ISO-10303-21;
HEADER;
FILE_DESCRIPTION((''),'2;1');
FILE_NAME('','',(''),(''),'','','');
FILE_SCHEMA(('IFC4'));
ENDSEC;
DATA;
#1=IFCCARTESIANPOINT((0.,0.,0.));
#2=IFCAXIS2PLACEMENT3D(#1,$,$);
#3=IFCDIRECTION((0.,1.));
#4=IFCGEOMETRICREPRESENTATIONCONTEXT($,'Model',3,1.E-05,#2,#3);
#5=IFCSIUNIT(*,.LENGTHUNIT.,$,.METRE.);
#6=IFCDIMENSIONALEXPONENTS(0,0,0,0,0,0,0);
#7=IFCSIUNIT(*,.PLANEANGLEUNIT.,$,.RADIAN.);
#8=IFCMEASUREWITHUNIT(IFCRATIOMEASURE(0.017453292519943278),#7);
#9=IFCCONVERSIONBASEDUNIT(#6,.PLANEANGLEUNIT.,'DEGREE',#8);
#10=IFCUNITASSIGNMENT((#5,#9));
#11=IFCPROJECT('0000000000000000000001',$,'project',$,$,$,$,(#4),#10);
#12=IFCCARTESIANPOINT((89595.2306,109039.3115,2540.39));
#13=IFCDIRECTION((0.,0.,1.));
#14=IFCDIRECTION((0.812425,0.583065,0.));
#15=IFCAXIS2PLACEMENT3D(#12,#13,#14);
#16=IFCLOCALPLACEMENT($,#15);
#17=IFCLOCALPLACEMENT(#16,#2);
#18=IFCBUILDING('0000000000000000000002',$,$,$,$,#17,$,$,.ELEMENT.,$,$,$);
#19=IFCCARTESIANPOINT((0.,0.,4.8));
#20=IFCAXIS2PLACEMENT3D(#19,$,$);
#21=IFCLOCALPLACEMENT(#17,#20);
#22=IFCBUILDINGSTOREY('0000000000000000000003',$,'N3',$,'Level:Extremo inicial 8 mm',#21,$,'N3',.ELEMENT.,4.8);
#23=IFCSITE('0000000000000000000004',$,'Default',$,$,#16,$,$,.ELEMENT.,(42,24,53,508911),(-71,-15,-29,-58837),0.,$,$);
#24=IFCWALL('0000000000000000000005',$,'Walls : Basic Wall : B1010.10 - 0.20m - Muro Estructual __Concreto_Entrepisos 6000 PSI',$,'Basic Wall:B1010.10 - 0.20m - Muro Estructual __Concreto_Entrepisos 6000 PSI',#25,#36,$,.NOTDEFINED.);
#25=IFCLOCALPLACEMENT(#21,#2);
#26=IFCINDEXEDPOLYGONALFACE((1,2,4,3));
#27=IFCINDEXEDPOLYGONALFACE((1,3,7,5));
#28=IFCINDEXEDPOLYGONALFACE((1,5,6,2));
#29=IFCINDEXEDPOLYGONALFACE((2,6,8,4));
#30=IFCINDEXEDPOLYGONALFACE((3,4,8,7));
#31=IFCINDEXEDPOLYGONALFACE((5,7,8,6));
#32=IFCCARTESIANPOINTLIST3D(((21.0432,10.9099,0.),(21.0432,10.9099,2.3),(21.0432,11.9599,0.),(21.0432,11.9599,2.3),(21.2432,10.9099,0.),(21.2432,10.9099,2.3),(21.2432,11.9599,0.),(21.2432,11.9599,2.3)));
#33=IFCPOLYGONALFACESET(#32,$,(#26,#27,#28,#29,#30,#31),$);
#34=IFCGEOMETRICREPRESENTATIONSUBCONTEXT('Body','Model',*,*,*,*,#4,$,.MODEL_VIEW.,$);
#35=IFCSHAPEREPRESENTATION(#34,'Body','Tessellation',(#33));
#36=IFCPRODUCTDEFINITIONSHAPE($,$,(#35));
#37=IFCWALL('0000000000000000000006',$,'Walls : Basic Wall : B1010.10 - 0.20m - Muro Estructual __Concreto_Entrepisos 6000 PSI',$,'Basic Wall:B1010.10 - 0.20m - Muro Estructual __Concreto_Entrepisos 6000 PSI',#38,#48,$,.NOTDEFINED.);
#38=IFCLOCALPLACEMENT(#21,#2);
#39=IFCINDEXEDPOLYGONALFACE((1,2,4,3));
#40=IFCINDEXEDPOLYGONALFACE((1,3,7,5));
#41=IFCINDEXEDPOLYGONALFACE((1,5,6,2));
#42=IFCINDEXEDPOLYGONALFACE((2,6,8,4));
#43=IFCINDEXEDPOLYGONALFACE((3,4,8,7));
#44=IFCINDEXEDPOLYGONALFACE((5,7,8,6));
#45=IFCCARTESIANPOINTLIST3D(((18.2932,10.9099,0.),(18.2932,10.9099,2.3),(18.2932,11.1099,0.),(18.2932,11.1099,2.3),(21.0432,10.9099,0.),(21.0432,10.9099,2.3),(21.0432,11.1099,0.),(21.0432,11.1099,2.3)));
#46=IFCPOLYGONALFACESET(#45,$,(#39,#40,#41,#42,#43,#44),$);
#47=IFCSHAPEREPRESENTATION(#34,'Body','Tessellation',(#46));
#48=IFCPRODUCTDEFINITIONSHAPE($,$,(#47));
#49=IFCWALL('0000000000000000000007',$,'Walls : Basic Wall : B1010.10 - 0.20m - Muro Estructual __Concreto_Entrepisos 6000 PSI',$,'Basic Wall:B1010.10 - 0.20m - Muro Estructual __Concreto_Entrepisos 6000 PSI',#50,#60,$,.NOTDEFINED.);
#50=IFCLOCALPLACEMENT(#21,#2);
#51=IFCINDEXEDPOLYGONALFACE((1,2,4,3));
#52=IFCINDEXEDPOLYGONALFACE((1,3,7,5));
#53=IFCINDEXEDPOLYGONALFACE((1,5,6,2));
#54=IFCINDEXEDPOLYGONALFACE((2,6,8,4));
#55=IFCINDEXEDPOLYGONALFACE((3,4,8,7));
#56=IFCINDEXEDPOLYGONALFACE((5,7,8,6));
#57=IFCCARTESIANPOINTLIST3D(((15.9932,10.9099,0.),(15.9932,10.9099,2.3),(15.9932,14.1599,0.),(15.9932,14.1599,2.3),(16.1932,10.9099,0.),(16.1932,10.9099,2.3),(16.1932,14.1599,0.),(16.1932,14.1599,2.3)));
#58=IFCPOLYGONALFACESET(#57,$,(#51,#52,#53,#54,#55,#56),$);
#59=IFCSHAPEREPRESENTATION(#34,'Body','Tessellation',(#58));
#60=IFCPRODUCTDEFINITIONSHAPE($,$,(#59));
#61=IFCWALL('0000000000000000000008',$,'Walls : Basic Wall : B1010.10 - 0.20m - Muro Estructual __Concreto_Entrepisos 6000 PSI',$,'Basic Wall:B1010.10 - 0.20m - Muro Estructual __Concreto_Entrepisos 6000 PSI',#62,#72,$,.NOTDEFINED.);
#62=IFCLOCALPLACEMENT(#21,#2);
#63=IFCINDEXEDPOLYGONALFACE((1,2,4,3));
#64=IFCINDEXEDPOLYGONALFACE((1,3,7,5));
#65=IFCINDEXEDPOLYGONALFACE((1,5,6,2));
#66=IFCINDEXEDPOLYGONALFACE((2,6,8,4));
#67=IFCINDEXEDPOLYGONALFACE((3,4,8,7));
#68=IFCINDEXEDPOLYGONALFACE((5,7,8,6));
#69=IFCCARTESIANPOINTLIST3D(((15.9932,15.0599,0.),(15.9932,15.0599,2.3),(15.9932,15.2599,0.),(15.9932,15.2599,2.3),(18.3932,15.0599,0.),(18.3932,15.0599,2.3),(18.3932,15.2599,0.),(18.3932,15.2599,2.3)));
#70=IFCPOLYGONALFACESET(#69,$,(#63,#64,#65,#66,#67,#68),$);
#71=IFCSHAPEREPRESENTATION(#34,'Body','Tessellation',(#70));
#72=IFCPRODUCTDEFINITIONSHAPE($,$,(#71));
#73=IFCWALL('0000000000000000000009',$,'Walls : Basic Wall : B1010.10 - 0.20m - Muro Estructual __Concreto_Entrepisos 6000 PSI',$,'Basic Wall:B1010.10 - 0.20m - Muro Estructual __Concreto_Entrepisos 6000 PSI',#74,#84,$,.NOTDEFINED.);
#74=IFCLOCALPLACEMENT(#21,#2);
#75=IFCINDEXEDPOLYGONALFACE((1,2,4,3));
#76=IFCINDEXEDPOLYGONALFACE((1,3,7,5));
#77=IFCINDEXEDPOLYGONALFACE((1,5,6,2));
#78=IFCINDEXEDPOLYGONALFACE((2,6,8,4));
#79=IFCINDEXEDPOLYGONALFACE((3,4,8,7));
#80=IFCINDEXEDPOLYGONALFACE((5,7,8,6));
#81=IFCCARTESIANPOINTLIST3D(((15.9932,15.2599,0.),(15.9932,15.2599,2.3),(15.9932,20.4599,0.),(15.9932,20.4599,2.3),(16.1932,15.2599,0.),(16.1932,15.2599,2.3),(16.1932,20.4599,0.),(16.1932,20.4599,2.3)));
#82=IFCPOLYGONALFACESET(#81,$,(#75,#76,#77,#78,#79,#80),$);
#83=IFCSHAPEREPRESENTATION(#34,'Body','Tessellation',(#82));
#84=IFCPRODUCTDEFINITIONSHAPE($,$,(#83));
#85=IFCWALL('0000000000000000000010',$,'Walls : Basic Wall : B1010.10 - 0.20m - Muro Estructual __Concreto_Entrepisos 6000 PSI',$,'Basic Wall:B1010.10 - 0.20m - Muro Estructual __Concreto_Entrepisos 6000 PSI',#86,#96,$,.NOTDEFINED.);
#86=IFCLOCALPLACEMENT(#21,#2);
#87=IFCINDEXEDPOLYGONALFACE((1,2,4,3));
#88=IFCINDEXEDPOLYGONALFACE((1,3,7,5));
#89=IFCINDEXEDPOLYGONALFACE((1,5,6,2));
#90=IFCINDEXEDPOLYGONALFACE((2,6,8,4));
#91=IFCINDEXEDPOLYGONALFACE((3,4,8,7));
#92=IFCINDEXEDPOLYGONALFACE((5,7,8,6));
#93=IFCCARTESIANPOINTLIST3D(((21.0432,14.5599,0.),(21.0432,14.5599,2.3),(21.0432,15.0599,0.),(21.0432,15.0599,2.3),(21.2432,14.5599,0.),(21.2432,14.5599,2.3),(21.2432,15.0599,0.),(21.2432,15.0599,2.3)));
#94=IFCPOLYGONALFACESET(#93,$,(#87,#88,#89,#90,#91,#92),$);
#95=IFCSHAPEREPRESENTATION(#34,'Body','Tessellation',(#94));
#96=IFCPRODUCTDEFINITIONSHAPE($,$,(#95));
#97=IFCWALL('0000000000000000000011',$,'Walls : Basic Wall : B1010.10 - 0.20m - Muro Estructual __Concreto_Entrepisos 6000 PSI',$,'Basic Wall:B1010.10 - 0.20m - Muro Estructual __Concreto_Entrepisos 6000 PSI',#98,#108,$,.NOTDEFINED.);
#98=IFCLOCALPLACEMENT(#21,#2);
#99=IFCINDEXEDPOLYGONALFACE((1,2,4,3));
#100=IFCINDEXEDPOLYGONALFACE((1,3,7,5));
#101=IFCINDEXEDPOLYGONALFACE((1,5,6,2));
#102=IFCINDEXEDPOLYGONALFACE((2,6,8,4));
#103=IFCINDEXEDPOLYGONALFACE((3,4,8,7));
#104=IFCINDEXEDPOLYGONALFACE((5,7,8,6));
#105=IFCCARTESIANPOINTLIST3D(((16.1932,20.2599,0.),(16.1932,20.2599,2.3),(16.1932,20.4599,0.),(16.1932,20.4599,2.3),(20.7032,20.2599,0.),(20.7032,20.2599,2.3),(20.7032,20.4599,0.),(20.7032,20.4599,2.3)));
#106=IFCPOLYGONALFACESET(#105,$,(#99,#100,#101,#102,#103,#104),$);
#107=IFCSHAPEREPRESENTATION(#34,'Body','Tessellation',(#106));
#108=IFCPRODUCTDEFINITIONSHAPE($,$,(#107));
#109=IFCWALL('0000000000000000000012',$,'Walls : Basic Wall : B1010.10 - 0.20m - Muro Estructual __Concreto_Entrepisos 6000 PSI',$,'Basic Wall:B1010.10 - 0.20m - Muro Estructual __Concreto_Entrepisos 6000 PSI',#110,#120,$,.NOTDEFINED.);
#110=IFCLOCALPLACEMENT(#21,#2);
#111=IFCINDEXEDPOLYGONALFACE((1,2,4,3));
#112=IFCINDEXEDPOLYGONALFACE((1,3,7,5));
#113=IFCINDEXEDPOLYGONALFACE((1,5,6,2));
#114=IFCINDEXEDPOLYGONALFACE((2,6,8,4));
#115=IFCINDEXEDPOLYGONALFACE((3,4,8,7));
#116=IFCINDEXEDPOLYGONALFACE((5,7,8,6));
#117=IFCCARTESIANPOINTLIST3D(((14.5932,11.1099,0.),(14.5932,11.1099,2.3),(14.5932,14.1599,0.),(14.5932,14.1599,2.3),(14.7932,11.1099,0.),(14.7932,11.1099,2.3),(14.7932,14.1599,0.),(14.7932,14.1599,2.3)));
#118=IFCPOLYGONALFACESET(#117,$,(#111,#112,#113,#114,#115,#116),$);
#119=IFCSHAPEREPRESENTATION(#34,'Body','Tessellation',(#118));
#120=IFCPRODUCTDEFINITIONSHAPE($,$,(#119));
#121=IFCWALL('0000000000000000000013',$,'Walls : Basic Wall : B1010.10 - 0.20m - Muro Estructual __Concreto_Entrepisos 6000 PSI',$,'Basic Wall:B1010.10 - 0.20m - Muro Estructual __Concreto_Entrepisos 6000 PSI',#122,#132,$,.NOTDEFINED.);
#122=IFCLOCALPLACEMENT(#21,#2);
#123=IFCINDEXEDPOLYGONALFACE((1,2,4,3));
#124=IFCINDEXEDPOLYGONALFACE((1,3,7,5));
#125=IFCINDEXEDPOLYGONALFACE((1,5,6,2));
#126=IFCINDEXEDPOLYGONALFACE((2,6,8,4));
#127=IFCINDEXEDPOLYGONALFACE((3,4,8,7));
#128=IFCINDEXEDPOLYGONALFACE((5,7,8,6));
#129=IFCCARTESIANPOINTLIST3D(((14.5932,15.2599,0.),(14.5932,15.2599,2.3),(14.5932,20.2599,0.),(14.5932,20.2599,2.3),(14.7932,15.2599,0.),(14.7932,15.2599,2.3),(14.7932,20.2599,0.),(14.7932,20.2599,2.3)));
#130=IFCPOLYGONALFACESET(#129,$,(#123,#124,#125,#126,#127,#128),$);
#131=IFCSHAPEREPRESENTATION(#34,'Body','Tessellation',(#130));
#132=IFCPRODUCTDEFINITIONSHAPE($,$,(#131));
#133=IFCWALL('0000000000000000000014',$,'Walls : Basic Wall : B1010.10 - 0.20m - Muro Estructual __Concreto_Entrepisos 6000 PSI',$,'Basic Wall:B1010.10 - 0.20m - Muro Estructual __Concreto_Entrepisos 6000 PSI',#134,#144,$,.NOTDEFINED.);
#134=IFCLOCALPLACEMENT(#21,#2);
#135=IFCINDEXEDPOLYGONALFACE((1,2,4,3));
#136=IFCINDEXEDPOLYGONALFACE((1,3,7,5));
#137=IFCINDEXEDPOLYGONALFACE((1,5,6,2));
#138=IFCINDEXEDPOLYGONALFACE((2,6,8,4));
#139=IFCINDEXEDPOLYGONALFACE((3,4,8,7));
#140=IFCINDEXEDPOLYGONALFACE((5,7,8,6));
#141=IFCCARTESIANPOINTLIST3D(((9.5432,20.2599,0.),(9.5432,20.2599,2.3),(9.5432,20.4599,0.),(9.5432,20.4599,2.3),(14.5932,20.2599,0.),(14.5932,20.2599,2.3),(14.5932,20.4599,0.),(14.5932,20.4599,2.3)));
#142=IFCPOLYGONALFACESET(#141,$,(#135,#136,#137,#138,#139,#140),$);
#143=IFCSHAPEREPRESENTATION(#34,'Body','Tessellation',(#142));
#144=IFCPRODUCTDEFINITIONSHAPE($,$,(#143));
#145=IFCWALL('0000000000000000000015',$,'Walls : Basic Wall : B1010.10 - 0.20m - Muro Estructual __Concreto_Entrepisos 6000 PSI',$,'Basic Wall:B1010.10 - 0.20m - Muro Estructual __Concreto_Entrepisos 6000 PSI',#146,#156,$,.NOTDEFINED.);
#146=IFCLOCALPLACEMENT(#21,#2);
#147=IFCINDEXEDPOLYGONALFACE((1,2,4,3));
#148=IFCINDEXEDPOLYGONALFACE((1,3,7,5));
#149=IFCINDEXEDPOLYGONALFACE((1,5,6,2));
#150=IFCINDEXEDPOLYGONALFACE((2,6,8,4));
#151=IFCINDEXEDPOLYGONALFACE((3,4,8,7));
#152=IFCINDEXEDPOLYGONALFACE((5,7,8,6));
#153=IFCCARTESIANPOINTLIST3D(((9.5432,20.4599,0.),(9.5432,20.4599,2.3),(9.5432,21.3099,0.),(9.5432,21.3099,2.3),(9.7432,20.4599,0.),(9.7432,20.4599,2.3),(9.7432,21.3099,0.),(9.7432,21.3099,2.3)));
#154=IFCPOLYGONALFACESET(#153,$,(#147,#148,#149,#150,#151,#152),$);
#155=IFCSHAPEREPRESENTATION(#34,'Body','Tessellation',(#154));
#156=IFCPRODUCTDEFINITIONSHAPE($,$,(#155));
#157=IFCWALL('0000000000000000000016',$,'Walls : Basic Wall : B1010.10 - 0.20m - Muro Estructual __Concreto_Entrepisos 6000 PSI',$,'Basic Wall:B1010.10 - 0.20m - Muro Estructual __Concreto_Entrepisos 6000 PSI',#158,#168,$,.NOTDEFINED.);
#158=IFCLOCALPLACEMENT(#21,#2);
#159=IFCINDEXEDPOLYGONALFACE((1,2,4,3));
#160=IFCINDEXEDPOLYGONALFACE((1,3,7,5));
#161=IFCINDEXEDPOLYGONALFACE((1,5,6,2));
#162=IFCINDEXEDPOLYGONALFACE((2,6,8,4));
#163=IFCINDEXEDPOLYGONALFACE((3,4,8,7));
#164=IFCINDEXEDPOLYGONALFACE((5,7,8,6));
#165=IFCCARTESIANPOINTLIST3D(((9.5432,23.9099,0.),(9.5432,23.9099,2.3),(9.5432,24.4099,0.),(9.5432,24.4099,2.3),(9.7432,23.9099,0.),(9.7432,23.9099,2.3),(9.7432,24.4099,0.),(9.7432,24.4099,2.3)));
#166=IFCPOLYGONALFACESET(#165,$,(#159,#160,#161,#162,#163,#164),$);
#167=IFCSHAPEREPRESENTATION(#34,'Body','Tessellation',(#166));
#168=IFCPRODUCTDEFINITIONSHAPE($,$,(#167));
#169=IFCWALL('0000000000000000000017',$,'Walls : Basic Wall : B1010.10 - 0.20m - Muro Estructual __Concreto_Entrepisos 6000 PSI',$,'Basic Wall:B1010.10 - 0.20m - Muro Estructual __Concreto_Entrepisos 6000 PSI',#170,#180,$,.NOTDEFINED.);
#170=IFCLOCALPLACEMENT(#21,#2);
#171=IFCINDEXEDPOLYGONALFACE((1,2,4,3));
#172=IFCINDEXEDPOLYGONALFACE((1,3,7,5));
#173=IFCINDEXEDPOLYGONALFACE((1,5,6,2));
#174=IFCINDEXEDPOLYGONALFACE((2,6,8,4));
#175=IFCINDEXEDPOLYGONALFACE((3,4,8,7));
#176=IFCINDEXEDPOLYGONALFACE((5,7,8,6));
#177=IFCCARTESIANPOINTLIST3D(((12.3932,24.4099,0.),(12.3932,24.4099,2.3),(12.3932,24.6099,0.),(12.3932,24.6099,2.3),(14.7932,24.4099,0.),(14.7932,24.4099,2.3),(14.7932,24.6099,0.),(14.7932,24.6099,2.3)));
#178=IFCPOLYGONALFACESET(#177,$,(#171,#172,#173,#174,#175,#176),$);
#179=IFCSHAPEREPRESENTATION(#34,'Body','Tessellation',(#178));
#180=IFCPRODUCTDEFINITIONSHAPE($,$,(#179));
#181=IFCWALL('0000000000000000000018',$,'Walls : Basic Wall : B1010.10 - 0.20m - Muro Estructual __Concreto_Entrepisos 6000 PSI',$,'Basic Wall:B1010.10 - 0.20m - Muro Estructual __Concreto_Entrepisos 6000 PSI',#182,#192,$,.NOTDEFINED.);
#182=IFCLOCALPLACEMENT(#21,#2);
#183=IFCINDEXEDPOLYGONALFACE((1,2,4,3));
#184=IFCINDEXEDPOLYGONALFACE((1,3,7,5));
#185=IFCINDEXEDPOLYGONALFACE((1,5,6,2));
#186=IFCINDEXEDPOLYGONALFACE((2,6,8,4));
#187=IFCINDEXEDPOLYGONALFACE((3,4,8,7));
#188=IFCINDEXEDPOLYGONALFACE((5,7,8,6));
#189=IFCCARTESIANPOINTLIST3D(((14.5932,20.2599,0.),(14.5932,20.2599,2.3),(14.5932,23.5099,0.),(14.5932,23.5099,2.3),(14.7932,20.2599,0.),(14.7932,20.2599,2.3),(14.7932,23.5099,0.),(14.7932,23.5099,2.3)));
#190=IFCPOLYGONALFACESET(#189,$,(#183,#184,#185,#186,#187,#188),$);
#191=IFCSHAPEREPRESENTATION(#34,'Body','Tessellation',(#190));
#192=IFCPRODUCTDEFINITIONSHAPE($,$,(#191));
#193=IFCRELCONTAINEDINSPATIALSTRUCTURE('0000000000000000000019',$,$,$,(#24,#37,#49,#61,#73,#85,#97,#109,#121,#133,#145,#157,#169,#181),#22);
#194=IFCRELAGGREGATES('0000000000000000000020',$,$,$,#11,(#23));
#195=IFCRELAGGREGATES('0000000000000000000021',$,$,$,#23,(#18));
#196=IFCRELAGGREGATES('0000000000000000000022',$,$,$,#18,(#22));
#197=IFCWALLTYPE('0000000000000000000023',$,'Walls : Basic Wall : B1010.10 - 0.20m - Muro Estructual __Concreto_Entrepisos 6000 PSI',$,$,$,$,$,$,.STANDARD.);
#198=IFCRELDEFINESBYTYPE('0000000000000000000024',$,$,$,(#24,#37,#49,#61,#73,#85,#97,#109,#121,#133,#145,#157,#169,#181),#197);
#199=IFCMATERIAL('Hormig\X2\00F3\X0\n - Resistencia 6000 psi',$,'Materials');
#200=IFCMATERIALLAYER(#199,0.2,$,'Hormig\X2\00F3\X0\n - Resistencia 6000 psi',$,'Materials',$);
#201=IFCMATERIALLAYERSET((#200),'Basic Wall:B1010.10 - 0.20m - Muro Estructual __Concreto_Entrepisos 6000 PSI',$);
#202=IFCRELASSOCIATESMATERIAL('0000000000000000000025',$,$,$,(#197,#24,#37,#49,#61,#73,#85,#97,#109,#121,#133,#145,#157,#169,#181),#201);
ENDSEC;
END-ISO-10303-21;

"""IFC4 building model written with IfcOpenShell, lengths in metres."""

from ifc_helpers import new_model, entity, si_unit, converted_unit, direction, frame, frame_2d, origin, place, context, subcontext, project, spatial, rectangle, extrude, material, layer, layer_set, layer_usage, type_object, element, save


model = new_model("IFC4")

# Units and contexts
model_context = context("Model", 3, precision=1e-05, world=origin(), true_north=direction((0.0, 1.0)))
body_context = subcontext(model_context, "Body", "Model", "MODEL_VIEW")
ifc_project = project(units=[si_unit("LENGTHUNIT", "METRE"), converted_unit("PLANEANGLEUNIT", "DEGREE", entity("IfcRatioMeasure", 0.017453292519943278), si_unit("PLANEANGLEUNIT", "RADIAN"), dimensions=[0, 0, 0, 0, 0, 0, 0])], contexts=[model_context])

# Site, building, storey
site_placement = place(None, frame((89595.2306, 109039.3115, 2540.39), z_axis=(0.0, 0.0, 1.0), x_axis=(0.812425, 0.583065, 0.0)))
site = spatial("IfcSite", under=ifc_project, at=site_placement, Name="Default", CompositionType="ELEMENT", RefLatitude=(42, 24, 53, 508911), RefLongitude=(-71, -15, -29, -58837), RefElevation=0.0)
building_placement = place(site_placement, origin())
building = spatial("IfcBuilding", under=site, at=building_placement, CompositionType="ELEMENT")
storey_placement = place(building_placement, frame((0.0, 0.0, 4.8)))
storey = spatial("IfcBuildingStorey", under=building, at=storey_placement, Name="N3", ObjectType="Level:Extremo inicial 8 mm", LongName="N3", CompositionType="ELEMENT", Elevation=4.8)

# Walls
ifc_material = material(Name="Hormigón - Resistencia 6000 psi", Category="Materials")
ifc_layer_1 = layer(ifc_material, 0.2, Name="Hormigón - Resistencia 6000 psi", Category="Materials")
ifc_layer_set_1 = layer_set([ifc_layer_1], Name="Basic Wall:B1010.10 - 0.20m - Muro Estructual __Concreto_Entrepisos 6000 PSI")
ifc_layer_usage_1 = layer_usage(ifc_layer_set_1, "AXIS2", "NEGATIVE", 0.1)
wall_type_1 = type_object("IfcWallType", Name="Walls : Basic Wall : B1010.10 - 0.20m - Muro Estructual __Concreto_Entrepisos 6000 PSI", PredefinedType="STANDARD", material=ifc_layer_set_1)
wall_1_placement = place(storey_placement, frame((21.1432, 11.9599, 0.0), z_axis=(0.0, 0.0, 1.0), x_axis=(0.0, -1.0, 0.0)))
element("IfcWall", 1, at=wall_1_placement, inside=storey, type_object=wall_type_1, material=ifc_layer_usage_1, Name="Walls : Basic Wall : B1010.10 - 0.20m - Muro Estructual __Concreto_Entrepisos 6000 PSI", ObjectType="Basic Wall:B1010.10 - 0.20m - Muro Estructual __Concreto_Entrepisos 6000 PSI", PredefinedType="NOTDEFINED", context=body_context, shape_type="SweptSolid", body=[
    extrude(rectangle(XDim=1.05, YDim=0.2, at=frame_2d((0.525, 0.0), x_axis=(-1.0, 0.0))), origin(), (0.0, 0.0, 1.0), 2.3),
])
ifc_layer_usage_2 = layer_usage(ifc_layer_set_1, "AXIS2", "NEGATIVE", 0.1)
wall_2_placement = place(storey_placement, frame((21.0432, 11.0099, 0.0), z_axis=(0.0, 0.0, 1.0), x_axis=(-1.0, 0.0, 0.0)))
element("IfcWall", 2, at=wall_2_placement, inside=storey, type_object=wall_type_1, material=ifc_layer_usage_2, Name="Walls : Basic Wall : B1010.10 - 0.20m - Muro Estructual __Concreto_Entrepisos 6000 PSI", ObjectType="Basic Wall:B1010.10 - 0.20m - Muro Estructual __Concreto_Entrepisos 6000 PSI", PredefinedType="NOTDEFINED", context=body_context, shape_type="SweptSolid", body=[
    extrude(rectangle(XDim=2.75, YDim=0.2, at=frame_2d((1.375, 0.0), x_axis=(-1.0, 0.0))), origin(), (0.0, 0.0, 1.0), 2.3),
])
ifc_layer_usage_3 = layer_usage(ifc_layer_set_1, "AXIS2", "NEGATIVE", 0.1)
wall_3_placement = place(storey_placement, frame((16.0932, 14.1599, 0.0), z_axis=(0.0, 0.0, 1.0), x_axis=(0.0, -1.0, 0.0)))
element("IfcWall", 3, at=wall_3_placement, inside=storey, type_object=wall_type_1, material=ifc_layer_usage_3, Name="Walls : Basic Wall : B1010.10 - 0.20m - Muro Estructual __Concreto_Entrepisos 6000 PSI", ObjectType="Basic Wall:B1010.10 - 0.20m - Muro Estructual __Concreto_Entrepisos 6000 PSI", PredefinedType="NOTDEFINED", context=body_context, shape_type="SweptSolid", body=[
    extrude(rectangle(XDim=3.25, YDim=0.2, at=frame_2d((1.625, 0.0), x_axis=(-1.0, 0.0))), origin(), (0.0, 0.0, 1.0), 2.3),
])
ifc_layer_usage_4 = layer_usage(ifc_layer_set_1, "AXIS2", "NEGATIVE", 0.1)
wall_4_placement = place(storey_placement, frame((18.3932, 15.1599, 0.0), z_axis=(0.0, 0.0, 1.0), x_axis=(-1.0, 0.0, 0.0)))
element("IfcWall", 4, at=wall_4_placement, inside=storey, type_object=wall_type_1, material=ifc_layer_usage_4, Name="Walls : Basic Wall : B1010.10 - 0.20m - Muro Estructual __Concreto_Entrepisos 6000 PSI", ObjectType="Basic Wall:B1010.10 - 0.20m - Muro Estructual __Concreto_Entrepisos 6000 PSI", PredefinedType="NOTDEFINED", context=body_context, shape_type="SweptSolid", body=[
    extrude(rectangle(XDim=2.4, YDim=0.2, at=frame_2d((1.2, 0.0), x_axis=(-1.0, 0.0))), origin(), (0.0, 0.0, 1.0), 2.3),
])
ifc_layer_usage_5 = layer_usage(ifc_layer_set_1, "AXIS2", "NEGATIVE", 0.1)
wall_5_placement = place(storey_placement, frame((16.0932, 15.2599, 0.0), z_axis=(0.0, 0.0, 1.0), x_axis=(0.0, 1.0, 0.0)))
element("IfcWall", 5, at=wall_5_placement, inside=storey, type_object=wall_type_1, material=ifc_layer_usage_5, Name="Walls : Basic Wall : B1010.10 - 0.20m - Muro Estructual __Concreto_Entrepisos 6000 PSI", ObjectType="Basic Wall:B1010.10 - 0.20m - Muro Estructual __Concreto_Entrepisos 6000 PSI", PredefinedType="NOTDEFINED", context=body_context, shape_type="SweptSolid", body=[
    extrude(rectangle(XDim=5.2, YDim=0.2, at=frame_2d((2.6, 0.0), x_axis=(-1.0, 0.0))), origin(), (0.0, 0.0, 1.0), 2.3),
])
ifc_layer_usage_6 = layer_usage(ifc_layer_set_1, "AXIS2", "NEGATIVE", 0.1)
wall_6_placement = place(storey_placement, frame((21.1432, 14.5599, 0.0), z_axis=(0.0, 0.0, 1.0), x_axis=(0.0, 1.0, 0.0)))
element("IfcWall", 6, at=wall_6_placement, inside=storey, type_object=wall_type_1, material=ifc_layer_usage_6, Name="Walls : Basic Wall : B1010.10 - 0.20m - Muro Estructual __Concreto_Entrepisos 6000 PSI", ObjectType="Basic Wall:B1010.10 - 0.20m - Muro Estructual __Concreto_Entrepisos 6000 PSI", PredefinedType="NOTDEFINED", context=body_context, shape_type="SweptSolid", body=[
    extrude(rectangle(XDim=0.5, YDim=0.2, at=frame_2d((0.25, 0.0), x_axis=(-1.0, 0.0))), origin(), (0.0, 0.0, 1.0), 2.3),
])
ifc_layer_usage_7 = layer_usage(ifc_layer_set_1, "AXIS2", "NEGATIVE", 0.1)
wall_7_placement = place(storey_placement, frame((16.1932, 20.3599, 0.0)))
element("IfcWall", 7, at=wall_7_placement, inside=storey, type_object=wall_type_1, material=ifc_layer_usage_7, Name="Walls : Basic Wall : B1010.10 - 0.20m - Muro Estructual __Concreto_Entrepisos 6000 PSI", ObjectType="Basic Wall:B1010.10 - 0.20m - Muro Estructual __Concreto_Entrepisos 6000 PSI", PredefinedType="NOTDEFINED", context=body_context, shape_type="SweptSolid", body=[
    extrude(rectangle(XDim=4.51, YDim=0.2, at=frame_2d((2.255, 0.0), x_axis=(-1.0, 0.0))), origin(), (0.0, 0.0, 1.0), 2.3),
])
ifc_layer_usage_8 = layer_usage(ifc_layer_set_1, "AXIS2", "POSITIVE", -0.1)
wall_8_placement = place(storey_placement, frame((14.6932, 14.1599, 0.0), z_axis=(0.0, 0.0, 1.0), x_axis=(0.0, -1.0, 0.0)))
element("IfcWall", 8, at=wall_8_placement, inside=storey, type_object=wall_type_1, material=ifc_layer_usage_8, Name="Walls : Basic Wall : B1010.10 - 0.20m - Muro Estructual __Concreto_Entrepisos 6000 PSI", ObjectType="Basic Wall:B1010.10 - 0.20m - Muro Estructual __Concreto_Entrepisos 6000 PSI", PredefinedType="NOTDEFINED", context=body_context, shape_type="SweptSolid", body=[
    extrude(rectangle(XDim=3.05, YDim=0.2, at=frame_2d((1.525, 0.0), x_axis=(-1.0, 0.0))), origin(), (0.0, 0.0, 1.0), 2.3),
])
ifc_layer_usage_9 = layer_usage(ifc_layer_set_1, "AXIS2", "POSITIVE", -0.1)
wall_9_placement = place(storey_placement, frame((14.6932, 15.2599, 0.0), z_axis=(0.0, 0.0, 1.0), x_axis=(0.0, 1.0, 0.0)))
element("IfcWall", 9, at=wall_9_placement, inside=storey, type_object=wall_type_1, material=ifc_layer_usage_9, Name="Walls : Basic Wall : B1010.10 - 0.20m - Muro Estructual __Concreto_Entrepisos 6000 PSI", ObjectType="Basic Wall:B1010.10 - 0.20m - Muro Estructual __Concreto_Entrepisos 6000 PSI", PredefinedType="NOTDEFINED", context=body_context, shape_type="SweptSolid", body=[
    extrude(rectangle(XDim=5.0, YDim=0.2, at=frame_2d((2.5, 0.0), x_axis=(-1.0, 0.0))), origin(), (0.0, 0.0, 1.0), 2.3),
])
ifc_layer_usage_10 = layer_usage(ifc_layer_set_1, "AXIS2", "POSITIVE", -0.1)
wall_10_placement = place(storey_placement, frame((14.5932, 20.3599, 0.0), z_axis=(0.0, 0.0, 1.0), x_axis=(-1.0, 0.0, 0.0)))
element("IfcWall", 10, at=wall_10_placement, inside=storey, type_object=wall_type_1, material=ifc_layer_usage_10, Name="Walls : Basic Wall : B1010.10 - 0.20m - Muro Estructual __Concreto_Entrepisos 6000 PSI", ObjectType="Basic Wall:B1010.10 - 0.20m - Muro Estructual __Concreto_Entrepisos 6000 PSI", PredefinedType="NOTDEFINED", context=body_context, shape_type="SweptSolid", body=[
    extrude(rectangle(XDim=5.05, YDim=0.2, at=frame_2d((2.525, 0.0), x_axis=(-1.0, 0.0))), origin(), (0.0, 0.0, 1.0), 2.3),
])
ifc_layer_usage_11 = layer_usage(ifc_layer_set_1, "AXIS2", "NEGATIVE", 0.1)
wall_11_placement = place(storey_placement, frame((9.6432, 20.4599, 0.0), z_axis=(0.0, 0.0, 1.0), x_axis=(0.0, 1.0, 0.0)))
element("IfcWall", 11, at=wall_11_placement, inside=storey, type_object=wall_type_1, material=ifc_layer_usage_11, Name="Walls : Basic Wall : B1010.10 - 0.20m - Muro Estructual __Concreto_Entrepisos 6000 PSI", ObjectType="Basic Wall:B1010.10 - 0.20m - Muro Estructual __Concreto_Entrepisos 6000 PSI", PredefinedType="NOTDEFINED", context=body_context, shape_type="SweptSolid", body=[
    extrude(rectangle(XDim=0.85, YDim=0.2, at=frame_2d((0.425, 0.0), x_axis=(-1.0, 0.0))), origin(), (0.0, 0.0, 1.0), 2.3),
])
ifc_layer_usage_12 = layer_usage(ifc_layer_set_1, "AXIS2", "NEGATIVE", 0.1)
wall_12_placement = place(storey_placement, frame((9.6432, 23.9099, 0.0), z_axis=(0.0, 0.0, 1.0), x_axis=(0.0, 1.0, 0.0)))
element("IfcWall", 12, at=wall_12_placement, inside=storey, type_object=wall_type_1, material=ifc_layer_usage_12, Name="Walls : Basic Wall : B1010.10 - 0.20m - Muro Estructual __Concreto_Entrepisos 6000 PSI", ObjectType="Basic Wall:B1010.10 - 0.20m - Muro Estructual __Concreto_Entrepisos 6000 PSI", PredefinedType="NOTDEFINED", context=body_context, shape_type="SweptSolid", body=[
    extrude(rectangle(XDim=0.5, YDim=0.2, at=frame_2d((0.25, 0.0), x_axis=(-1.0, 0.0))), origin(), (0.0, 0.0, 1.0), 2.3),
])
ifc_layer_usage_13 = layer_usage(ifc_layer_set_1, "AXIS2", "NEGATIVE", 0.1)
wall_13_placement = place(storey_placement, frame((12.3932, 24.5099, 0.0)))
element("IfcWall", 13, at=wall_13_placement, inside=storey, type_object=wall_type_1, material=ifc_layer_usage_13, Name="Walls : Basic Wall : B1010.10 - 0.20m - Muro Estructual __Concreto_Entrepisos 6000 PSI", ObjectType="Basic Wall:B1010.10 - 0.20m - Muro Estructual __Concreto_Entrepisos 6000 PSI", PredefinedType="NOTDEFINED", context=body_context, shape_type="SweptSolid", body=[
    extrude(rectangle(XDim=2.4, YDim=0.2, at=frame_2d((1.2, 0.0), x_axis=(-1.0, 0.0))), origin(), (0.0, 0.0, 1.0), 2.3),
])
ifc_layer_usage_14 = layer_usage(ifc_layer_set_1, "AXIS2", "POSITIVE", -0.1)
wall_14_placement = place(storey_placement, frame((14.6932, 20.2599, 0.0), z_axis=(0.0, 0.0, 1.0), x_axis=(0.0, 1.0, 0.0)))
element("IfcWall", 14, at=wall_14_placement, inside=storey, type_object=wall_type_1, material=ifc_layer_usage_14, Name="Walls : Basic Wall : B1010.10 - 0.20m - Muro Estructual __Concreto_Entrepisos 6000 PSI", ObjectType="Basic Wall:B1010.10 - 0.20m - Muro Estructual __Concreto_Entrepisos 6000 PSI", PredefinedType="NOTDEFINED", context=body_context, shape_type="SweptSolid", body=[
    extrude(rectangle(XDim=3.25, YDim=0.2, at=frame_2d((1.625, 0.0), x_axis=(-1.0, 0.0))), origin(), (0.0, 0.0, 1.0), 2.3),
])

save(model, "model.ifc")
